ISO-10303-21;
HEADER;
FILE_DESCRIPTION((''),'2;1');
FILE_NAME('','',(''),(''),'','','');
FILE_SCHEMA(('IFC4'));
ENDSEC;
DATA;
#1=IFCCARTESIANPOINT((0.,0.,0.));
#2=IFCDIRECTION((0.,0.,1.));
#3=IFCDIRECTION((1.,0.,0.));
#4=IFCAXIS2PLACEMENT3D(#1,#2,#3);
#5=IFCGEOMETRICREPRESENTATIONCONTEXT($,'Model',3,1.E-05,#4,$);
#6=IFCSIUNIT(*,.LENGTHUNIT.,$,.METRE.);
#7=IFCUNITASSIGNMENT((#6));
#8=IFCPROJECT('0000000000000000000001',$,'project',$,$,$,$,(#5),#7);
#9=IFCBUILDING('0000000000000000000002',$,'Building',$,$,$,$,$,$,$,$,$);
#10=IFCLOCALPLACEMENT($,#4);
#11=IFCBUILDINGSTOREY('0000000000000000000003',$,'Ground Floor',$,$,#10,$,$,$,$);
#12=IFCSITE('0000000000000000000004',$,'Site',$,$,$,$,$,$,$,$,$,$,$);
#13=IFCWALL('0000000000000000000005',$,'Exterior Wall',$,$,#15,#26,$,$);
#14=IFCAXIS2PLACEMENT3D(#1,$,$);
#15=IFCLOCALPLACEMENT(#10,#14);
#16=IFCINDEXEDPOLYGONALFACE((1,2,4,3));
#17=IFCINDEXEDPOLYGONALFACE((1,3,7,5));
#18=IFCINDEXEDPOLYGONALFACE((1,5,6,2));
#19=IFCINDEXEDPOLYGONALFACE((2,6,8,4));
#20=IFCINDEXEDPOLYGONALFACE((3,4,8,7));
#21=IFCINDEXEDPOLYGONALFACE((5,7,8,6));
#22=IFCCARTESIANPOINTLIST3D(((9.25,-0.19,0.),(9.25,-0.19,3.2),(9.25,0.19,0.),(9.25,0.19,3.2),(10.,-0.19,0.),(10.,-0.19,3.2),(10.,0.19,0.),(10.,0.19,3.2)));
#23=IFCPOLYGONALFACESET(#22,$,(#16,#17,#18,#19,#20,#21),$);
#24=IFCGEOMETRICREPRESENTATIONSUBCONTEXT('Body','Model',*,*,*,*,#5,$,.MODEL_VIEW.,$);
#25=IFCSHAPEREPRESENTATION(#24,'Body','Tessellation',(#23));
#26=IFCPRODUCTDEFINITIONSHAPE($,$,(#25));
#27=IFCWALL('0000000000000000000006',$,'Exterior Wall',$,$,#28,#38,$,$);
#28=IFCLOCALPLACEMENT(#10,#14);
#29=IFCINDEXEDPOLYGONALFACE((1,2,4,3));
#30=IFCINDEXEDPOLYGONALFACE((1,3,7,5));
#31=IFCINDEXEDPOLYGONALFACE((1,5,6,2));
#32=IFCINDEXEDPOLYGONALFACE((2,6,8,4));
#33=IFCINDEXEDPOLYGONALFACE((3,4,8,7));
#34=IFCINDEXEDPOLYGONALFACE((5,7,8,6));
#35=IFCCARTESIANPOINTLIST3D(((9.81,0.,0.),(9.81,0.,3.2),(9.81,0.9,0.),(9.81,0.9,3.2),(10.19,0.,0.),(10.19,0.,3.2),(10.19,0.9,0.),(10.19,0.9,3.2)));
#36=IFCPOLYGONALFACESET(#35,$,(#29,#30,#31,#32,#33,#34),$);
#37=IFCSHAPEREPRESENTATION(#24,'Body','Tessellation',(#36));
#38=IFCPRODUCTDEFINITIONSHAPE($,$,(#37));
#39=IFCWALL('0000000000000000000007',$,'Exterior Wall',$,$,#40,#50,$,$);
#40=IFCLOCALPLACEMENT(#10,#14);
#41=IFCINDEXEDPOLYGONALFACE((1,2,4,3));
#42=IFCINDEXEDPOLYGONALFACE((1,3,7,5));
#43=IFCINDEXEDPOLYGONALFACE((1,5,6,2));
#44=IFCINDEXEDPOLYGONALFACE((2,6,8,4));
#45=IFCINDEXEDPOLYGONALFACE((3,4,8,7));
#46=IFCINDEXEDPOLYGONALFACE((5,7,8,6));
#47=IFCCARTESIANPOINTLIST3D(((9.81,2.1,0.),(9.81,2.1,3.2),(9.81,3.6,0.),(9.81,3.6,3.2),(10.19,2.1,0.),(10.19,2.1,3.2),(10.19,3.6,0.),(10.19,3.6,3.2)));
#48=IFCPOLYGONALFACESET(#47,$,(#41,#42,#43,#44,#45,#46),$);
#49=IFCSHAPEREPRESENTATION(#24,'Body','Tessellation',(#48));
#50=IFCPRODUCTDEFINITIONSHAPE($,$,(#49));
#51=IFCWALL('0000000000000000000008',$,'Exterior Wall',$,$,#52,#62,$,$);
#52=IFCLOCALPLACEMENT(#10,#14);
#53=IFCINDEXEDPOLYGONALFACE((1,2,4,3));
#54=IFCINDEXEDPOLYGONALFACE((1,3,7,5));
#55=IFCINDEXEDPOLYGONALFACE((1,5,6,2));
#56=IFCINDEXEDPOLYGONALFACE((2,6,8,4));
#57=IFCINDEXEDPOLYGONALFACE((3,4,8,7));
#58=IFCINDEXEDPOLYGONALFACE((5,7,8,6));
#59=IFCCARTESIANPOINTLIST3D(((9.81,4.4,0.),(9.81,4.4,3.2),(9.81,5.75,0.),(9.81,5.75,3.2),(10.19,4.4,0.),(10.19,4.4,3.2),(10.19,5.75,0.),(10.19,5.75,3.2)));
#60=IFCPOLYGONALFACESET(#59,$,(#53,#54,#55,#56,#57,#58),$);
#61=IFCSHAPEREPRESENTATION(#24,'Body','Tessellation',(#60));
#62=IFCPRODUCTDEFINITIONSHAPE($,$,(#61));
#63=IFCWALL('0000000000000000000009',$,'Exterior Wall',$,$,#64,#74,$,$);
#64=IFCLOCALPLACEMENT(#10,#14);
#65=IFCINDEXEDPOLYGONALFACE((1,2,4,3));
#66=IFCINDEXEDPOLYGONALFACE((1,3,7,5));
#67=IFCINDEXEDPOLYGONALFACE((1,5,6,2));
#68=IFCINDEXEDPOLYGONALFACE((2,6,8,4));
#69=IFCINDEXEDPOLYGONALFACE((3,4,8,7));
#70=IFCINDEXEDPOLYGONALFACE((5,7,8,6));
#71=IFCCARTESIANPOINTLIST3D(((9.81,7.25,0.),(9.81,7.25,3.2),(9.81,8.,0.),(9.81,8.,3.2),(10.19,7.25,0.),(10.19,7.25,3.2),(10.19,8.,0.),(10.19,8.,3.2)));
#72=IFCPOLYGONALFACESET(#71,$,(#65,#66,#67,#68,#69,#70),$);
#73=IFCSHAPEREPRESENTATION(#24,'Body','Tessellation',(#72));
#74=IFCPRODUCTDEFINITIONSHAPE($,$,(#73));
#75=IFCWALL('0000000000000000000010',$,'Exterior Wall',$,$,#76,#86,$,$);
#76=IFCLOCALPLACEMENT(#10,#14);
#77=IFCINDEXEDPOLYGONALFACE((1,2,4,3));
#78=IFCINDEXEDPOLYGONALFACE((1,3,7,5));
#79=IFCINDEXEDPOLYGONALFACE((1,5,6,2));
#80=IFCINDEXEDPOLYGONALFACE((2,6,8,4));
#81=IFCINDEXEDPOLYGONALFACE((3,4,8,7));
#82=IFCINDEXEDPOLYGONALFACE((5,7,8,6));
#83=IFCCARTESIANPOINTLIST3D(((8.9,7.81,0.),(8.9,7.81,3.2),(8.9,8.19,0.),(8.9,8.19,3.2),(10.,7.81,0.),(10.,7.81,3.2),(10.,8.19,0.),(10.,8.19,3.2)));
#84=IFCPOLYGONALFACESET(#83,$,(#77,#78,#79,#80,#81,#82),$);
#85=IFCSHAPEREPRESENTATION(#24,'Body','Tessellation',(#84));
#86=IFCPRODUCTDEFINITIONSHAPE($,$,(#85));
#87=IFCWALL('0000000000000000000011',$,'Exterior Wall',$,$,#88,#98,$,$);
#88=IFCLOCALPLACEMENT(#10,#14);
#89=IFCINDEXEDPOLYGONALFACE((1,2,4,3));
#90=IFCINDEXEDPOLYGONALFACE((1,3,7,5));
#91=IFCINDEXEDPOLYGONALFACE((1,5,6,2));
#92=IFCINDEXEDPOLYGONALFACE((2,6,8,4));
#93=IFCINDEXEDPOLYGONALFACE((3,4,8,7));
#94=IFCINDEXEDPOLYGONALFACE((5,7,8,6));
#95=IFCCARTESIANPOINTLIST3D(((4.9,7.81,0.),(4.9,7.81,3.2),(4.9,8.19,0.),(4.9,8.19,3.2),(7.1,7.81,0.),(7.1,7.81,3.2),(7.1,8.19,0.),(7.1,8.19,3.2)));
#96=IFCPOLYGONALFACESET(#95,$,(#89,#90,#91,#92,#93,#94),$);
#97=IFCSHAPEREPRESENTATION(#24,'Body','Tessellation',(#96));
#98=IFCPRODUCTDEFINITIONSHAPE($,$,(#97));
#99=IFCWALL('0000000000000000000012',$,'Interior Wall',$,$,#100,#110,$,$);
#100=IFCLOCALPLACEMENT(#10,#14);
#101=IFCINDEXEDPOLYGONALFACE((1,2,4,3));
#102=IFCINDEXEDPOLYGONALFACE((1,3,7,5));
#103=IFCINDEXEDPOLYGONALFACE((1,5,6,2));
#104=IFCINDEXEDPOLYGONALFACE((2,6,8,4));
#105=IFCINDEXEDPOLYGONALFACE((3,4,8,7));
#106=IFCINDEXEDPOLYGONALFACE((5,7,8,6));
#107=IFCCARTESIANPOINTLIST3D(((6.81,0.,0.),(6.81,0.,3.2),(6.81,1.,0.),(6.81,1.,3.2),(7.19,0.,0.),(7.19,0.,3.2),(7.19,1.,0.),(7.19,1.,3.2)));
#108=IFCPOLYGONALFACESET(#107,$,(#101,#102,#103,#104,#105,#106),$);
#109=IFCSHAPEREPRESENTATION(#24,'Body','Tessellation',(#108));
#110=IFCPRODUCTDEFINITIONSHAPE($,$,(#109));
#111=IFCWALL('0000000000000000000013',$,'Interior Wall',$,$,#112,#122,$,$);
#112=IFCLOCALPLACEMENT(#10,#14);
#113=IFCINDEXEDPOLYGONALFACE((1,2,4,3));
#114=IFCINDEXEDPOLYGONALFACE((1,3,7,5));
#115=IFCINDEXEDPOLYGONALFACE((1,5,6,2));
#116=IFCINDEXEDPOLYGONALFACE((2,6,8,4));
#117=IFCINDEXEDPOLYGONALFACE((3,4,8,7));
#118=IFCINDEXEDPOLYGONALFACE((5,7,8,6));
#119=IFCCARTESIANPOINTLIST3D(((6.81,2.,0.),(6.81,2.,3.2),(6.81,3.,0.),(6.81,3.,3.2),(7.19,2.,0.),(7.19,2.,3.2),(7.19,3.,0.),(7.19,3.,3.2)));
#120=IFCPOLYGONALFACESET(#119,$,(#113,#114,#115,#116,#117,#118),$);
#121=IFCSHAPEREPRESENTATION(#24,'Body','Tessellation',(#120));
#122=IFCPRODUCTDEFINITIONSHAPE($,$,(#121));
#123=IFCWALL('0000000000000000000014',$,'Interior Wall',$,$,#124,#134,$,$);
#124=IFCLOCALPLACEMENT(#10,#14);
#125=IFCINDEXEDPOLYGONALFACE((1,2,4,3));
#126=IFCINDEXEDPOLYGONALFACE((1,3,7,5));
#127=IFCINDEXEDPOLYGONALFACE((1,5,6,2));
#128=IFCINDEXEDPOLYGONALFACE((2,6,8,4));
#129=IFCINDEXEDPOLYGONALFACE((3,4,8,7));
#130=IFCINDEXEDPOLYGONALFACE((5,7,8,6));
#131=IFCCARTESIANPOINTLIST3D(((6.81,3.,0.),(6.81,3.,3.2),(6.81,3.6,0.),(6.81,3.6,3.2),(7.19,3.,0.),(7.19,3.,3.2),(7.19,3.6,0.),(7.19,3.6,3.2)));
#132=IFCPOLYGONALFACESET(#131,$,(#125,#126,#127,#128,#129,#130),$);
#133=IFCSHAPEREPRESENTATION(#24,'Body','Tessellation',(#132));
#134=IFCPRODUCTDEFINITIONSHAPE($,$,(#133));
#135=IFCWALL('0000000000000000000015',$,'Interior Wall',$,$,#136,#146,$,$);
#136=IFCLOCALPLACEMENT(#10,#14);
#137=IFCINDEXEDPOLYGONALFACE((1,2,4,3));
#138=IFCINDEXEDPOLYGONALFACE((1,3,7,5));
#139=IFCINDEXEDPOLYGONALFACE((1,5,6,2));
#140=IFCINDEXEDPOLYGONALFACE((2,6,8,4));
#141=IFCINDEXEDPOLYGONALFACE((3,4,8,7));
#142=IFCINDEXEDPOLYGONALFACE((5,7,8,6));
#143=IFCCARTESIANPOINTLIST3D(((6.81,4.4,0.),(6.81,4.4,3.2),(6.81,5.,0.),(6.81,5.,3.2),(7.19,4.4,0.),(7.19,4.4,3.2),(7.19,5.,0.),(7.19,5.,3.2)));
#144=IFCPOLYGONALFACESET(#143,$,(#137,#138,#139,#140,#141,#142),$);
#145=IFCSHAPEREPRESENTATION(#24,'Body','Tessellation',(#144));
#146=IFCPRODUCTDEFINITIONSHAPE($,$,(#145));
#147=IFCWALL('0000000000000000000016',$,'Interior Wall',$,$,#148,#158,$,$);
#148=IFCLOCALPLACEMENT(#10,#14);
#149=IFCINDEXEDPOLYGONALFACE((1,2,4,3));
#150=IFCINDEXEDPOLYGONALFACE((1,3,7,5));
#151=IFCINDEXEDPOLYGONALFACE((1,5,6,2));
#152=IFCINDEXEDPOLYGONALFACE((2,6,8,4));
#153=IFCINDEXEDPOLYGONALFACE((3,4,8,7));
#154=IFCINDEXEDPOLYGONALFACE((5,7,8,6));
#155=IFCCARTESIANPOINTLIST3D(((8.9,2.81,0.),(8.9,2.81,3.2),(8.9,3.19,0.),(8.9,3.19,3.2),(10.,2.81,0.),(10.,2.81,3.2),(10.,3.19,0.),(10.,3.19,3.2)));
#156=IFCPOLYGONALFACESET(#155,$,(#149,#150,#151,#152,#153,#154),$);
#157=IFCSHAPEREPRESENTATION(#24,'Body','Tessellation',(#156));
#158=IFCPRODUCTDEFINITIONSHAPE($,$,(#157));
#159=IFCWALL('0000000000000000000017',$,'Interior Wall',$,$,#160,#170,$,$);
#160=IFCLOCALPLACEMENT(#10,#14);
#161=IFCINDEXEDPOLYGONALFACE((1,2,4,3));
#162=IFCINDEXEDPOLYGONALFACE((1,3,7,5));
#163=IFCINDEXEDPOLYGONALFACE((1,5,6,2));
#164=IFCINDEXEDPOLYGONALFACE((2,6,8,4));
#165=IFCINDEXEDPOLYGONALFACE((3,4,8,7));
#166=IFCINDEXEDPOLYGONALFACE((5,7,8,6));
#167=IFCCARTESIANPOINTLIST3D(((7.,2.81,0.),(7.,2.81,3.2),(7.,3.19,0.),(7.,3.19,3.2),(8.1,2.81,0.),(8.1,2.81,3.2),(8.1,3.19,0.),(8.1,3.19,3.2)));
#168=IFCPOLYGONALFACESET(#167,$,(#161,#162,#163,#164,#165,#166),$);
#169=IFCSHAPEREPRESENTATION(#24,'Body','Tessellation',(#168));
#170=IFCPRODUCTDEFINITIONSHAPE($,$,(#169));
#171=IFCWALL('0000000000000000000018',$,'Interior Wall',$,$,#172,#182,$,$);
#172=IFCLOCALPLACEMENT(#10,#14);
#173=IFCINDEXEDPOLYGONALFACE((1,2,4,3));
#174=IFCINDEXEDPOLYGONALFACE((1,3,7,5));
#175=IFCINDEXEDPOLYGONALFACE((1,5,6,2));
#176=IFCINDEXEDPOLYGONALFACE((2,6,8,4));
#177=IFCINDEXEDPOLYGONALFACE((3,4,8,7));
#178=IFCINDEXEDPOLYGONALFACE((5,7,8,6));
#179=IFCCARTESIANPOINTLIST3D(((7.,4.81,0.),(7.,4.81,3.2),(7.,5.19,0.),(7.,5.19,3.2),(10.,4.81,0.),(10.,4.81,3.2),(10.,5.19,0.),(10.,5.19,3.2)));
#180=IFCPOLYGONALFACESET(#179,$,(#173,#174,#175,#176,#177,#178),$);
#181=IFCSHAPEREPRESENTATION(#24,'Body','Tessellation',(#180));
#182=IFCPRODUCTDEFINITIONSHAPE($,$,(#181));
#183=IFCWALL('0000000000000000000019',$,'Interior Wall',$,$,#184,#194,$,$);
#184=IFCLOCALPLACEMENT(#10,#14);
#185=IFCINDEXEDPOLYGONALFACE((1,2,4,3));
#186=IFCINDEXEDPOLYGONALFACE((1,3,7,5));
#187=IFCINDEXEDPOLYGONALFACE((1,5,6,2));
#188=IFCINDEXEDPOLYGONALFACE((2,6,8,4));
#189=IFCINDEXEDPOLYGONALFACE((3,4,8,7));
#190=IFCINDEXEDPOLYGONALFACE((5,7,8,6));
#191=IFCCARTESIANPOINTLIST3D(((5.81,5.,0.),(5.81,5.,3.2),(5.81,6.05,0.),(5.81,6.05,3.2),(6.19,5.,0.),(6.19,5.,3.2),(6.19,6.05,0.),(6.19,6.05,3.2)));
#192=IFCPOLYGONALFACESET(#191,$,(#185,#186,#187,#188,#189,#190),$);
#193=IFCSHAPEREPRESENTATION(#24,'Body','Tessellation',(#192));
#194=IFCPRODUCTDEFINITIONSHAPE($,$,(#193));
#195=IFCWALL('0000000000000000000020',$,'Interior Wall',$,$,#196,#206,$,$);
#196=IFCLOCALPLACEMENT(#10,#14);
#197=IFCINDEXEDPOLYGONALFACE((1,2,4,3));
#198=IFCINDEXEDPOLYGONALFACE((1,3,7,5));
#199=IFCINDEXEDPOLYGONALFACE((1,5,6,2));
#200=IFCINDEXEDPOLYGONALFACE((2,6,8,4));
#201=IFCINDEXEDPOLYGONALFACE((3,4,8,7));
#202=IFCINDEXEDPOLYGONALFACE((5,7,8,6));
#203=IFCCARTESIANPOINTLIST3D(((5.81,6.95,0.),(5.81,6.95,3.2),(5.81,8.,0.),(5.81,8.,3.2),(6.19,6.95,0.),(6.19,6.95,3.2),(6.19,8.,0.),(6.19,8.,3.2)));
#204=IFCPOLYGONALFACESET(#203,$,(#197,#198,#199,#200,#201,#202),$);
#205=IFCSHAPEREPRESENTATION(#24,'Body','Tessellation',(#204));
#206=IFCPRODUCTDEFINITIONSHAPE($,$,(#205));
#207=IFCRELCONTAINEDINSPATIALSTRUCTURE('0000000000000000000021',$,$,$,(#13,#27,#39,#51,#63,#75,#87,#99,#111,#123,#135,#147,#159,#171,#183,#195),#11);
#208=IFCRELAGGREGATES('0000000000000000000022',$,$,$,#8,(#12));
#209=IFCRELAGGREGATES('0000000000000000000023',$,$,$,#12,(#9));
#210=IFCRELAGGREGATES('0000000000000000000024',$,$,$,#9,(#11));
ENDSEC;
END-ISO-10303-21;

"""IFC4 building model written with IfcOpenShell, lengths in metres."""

from ifc_helpers import new_model, si_unit, frame, origin_with_axes, place, context, subcontext, project, spatial, indexed_curve, outline, extrude, element, save


model = new_model("IFC4")

# Units and contexts
model_context = context("Model", 3, precision=1e-05, world=origin_with_axes())
body_context = subcontext(model_context, "Body", "Model", "MODEL_VIEW")
ifc_project = project(units=[si_unit("LENGTHUNIT", "METRE")], contexts=[model_context])

# Site, building, storey
site = spatial("IfcSite", under=ifc_project, Name="Site")
building = spatial("IfcBuilding", under=site, Name="Building")
storey_placement = place(None, origin_with_axes())
storey = spatial("IfcBuildingStorey", under=building, at=storey_placement, Name="Ground Floor")

# Walls
wall_1_placement = place(storey_placement, frame((9.25, 0.0, 0.0), z_axis=(0.0, 0.0, 1.0), x_axis=(1.0, 0.0, 0.0)))
element("IfcWall", 1, at=wall_1_placement, inside=storey, Name="Exterior Wall", context=body_context, shape_type="SweptSolid", body=[
    extrude(outline(indexed_curve([(0.0, 0.0), (0.0, 0.38), (0.75, 0.38), (0.75, 0.0), (0.0, 0.0)], self_intersect=False)), frame((0.0, -0.19, 0.0), z_axis=(0.0, 0.0, 1.0), x_axis=(1.0, 0.0, 0.0)), (0.0, 0.0, 1.0), 3.2),
])
wall_2_placement = place(storey_placement, frame((10.0, 0.0, 0.0), z_axis=(0.0, 0.0, 1.0), x_axis=(0.0, 1.0, 0.0)))
element("IfcWall", 2, at=wall_2_placement, inside=storey, Name="Exterior Wall", context=body_context, shape_type="SweptSolid", body=[
    extrude(outline(indexed_curve([(0.0, 0.0), (0.0, 0.38), (0.9, 0.38), (0.9, 0.0), (0.0, 0.0)], self_intersect=False)), frame((0.0, -0.19, 0.0), z_axis=(0.0, 0.0, 1.0), x_axis=(1.0, 0.0, 0.0)), (0.0, 0.0, 1.0), 3.2),
])
wall_3_placement = place(storey_placement, frame((10.0, 2.1, 0.0), z_axis=(0.0, 0.0, 1.0), x_axis=(0.0, 1.0, 0.0)))
element("IfcWall", 3, at=wall_3_placement, inside=storey, Name="Exterior Wall", context=body_context, shape_type="SweptSolid", body=[
    extrude(outline(indexed_curve([(0.0, 0.0), (0.0, 0.38), (1.5, 0.38), (1.5, 0.0), (0.0, 0.0)], self_intersect=False)), frame((0.0, -0.19, 0.0), z_axis=(0.0, 0.0, 1.0), x_axis=(1.0, 0.0, 0.0)), (0.0, 0.0, 1.0), 3.2),
])
wall_4_placement = place(storey_placement, frame((10.0, 4.4, 0.0), z_axis=(0.0, 0.0, 1.0), x_axis=(0.0, 1.0, 0.0)))
element("IfcWall", 4, at=wall_4_placement, inside=storey, Name="Exterior Wall", context=body_context, shape_type="SweptSolid", body=[
    extrude(outline(indexed_curve([(0.0, 0.0), (0.0, 0.38), (1.35, 0.38), (1.35, 0.0), (0.0, 0.0)], self_intersect=False)), frame((0.0, -0.19, 0.0), z_axis=(0.0, 0.0, 1.0), x_axis=(1.0, 0.0, 0.0)), (0.0, 0.0, 1.0), 3.2),
])
wall_5_placement = place(storey_placement, frame((10.0, 7.25, 0.0), z_axis=(0.0, 0.0, 1.0), x_axis=(0.0, 1.0, 0.0)))
element("IfcWall", 5, at=wall_5_placement, inside=storey, Name="Exterior Wall", context=body_context, shape_type="SweptSolid", body=[
    extrude(outline(indexed_curve([(0.0, 0.0), (0.0, 0.38), (0.75, 0.38), (0.75, 0.0), (0.0, 0.0)], self_intersect=False)), frame((0.0, -0.19, 0.0), z_axis=(0.0, 0.0, 1.0), x_axis=(1.0, 0.0, 0.0)), (0.0, 0.0, 1.0), 3.2),
])
wall_6_placement = place(storey_placement, frame((10.0, 8.0, 0.0), z_axis=(0.0, 0.0, 1.0), x_axis=(-1.0, 0.0, 0.0)))
element("IfcWall", 6, at=wall_6_placement, inside=storey, Name="Exterior Wall", context=body_context, shape_type="SweptSolid", body=[
    extrude(outline(indexed_curve([(0.0, 0.0), (0.0, 0.38), (1.1, 0.38), (1.1, 0.0), (0.0, 0.0)], self_intersect=False)), frame((0.0, -0.19, 0.0), z_axis=(0.0, 0.0, 1.0), x_axis=(1.0, 0.0, 0.0)), (0.0, 0.0, 1.0), 3.2),
])
wall_7_placement = place(storey_placement, frame((7.1, 8.0, 0.0), z_axis=(0.0, 0.0, 1.0), x_axis=(-1.0, 0.0, 0.0)))
element("IfcWall", 7, at=wall_7_placement, inside=storey, Name="Exterior Wall", context=body_context, shape_type="SweptSolid", body=[
    extrude(outline(indexed_curve([(0.0, 0.0), (0.0, 0.38), (2.2, 0.38), (2.2, 0.0), (0.0, 0.0)], self_intersect=False)), frame((0.0, -0.19, 0.0), z_axis=(0.0, 0.0, 1.0), x_axis=(1.0, 0.0, 0.0)), (0.0, 0.0, 1.0), 3.2),
])
for number, where, z_axis, x_axis, name in (
    (8, (7.0, 0.0, 0.0), (0.0, 0.0, 1.0), (0.0, 1.0, 0.0), "Interior Wall"),
    (9, (7.0, 2.0, 0.0), (0.0, 0.0, 1.0), (0.0, 1.0, 0.0), "Interior Wall"),
):
    element("IfcWall", number, at=place(storey_placement, frame(where, z_axis=z_axis, x_axis=x_axis)), inside=storey, Name=name, context=body_context, shape_type="SweptSolid", body=[
        extrude(outline(indexed_curve([(0.0, 0.0), (0.0, 0.38), (1.0, 0.38), (1.0, 0.0), (0.0, 0.0)], self_intersect=False)), frame((0.0, -0.19, 0.0), z_axis=(0.0, 0.0, 1.0), x_axis=(1.0, 0.0, 0.0)), (0.0, 0.0, 1.0), 3.2),
    ])
wall_8_placement = place(storey_placement, frame((7.0, 3.0, 0.0), z_axis=(0.0, 0.0, 1.0), x_axis=(0.0, 1.0, 0.0)))
element("IfcWall", 10, at=wall_8_placement, inside=storey, Name="Interior Wall", context=body_context, shape_type="SweptSolid", body=[
    extrude(outline(indexed_curve([(0.0, 0.0), (0.0, 0.38), (0.6, 0.38), (0.6, 0.0), (0.0, 0.0)], self_intersect=False)), frame((0.0, -0.19, 0.0), z_axis=(0.0, 0.0, 1.0), x_axis=(1.0, 0.0, 0.0)), (0.0, 0.0, 1.0), 3.2),
])
wall_9_placement = place(storey_placement, frame((7.0, 4.4, 0.0), z_axis=(0.0, 0.0, 1.0), x_axis=(0.0, 1.0, 0.0)))
element("IfcWall", 11, at=wall_9_placement, inside=storey, Name="Interior Wall", context=body_context, shape_type="SweptSolid", body=[
    extrude(outline(indexed_curve([(0.0, 0.0), (0.0, 0.38), (0.6, 0.38), (0.6, 0.0), (0.0, 0.0)], self_intersect=False)), frame((0.0, -0.19, 0.0), z_axis=(0.0, 0.0, 1.0), x_axis=(1.0, 0.0, 0.0)), (0.0, 0.0, 1.0), 3.2),
])
for number, where, z_axis, x_axis, name in (
    (12, (10.0, 3.0, 0.0), (0.0, 0.0, 1.0), (-1.0, 0.0, 0.0), "Interior Wall"),
    (13, (8.1, 3.0, 0.0), (0.0, 0.0, 1.0), (-1.0, 0.0, 0.0), "Interior Wall"),
):
    element("IfcWall", number, at=place(storey_placement, frame(where, z_axis=z_axis, x_axis=x_axis)), inside=storey, Name=name, context=body_context, shape_type="SweptSolid", body=[
        extrude(outline(indexed_curve([(0.0, 0.0), (0.0, 0.38), (1.1, 0.38), (1.1, 0.0), (0.0, 0.0)], self_intersect=False)), frame((0.0, -0.19, 0.0), z_axis=(0.0, 0.0, 1.0), x_axis=(1.0, 0.0, 0.0)), (0.0, 0.0, 1.0), 3.2),
    ])
wall_10_placement = place(storey_placement, frame((10.0, 5.0, 0.0), z_axis=(0.0, 0.0, 1.0), x_axis=(-1.0, 0.0, 0.0)))
element("IfcWall", 14, at=wall_10_placement, inside=storey, Name="Interior Wall", context=body_context, shape_type="SweptSolid", body=[
    extrude(outline(indexed_curve([(0.0, 0.0), (0.0, 0.38), (3.0, 0.38), (3.0, 0.0), (0.0, 0.0)], self_intersect=False)), frame((0.0, -0.19, 0.0), z_axis=(0.0, 0.0, 1.0), x_axis=(1.0, 0.0, 0.0)), (0.0, 0.0, 1.0), 3.2),
])
for number, where, z_axis, x_axis, name in (
    (15, (6.0, 5.0, 0.0), (0.0, 0.0, 1.0), (0.0, 1.0, 0.0), "Interior Wall"),
    (16, (6.0, 6.95, 0.0), (0.0, 0.0, 1.0), (0.0, 1.0, 0.0), "Interior Wall"),
):
    element("IfcWall", number, at=place(storey_placement, frame(where, z_axis=z_axis, x_axis=x_axis)), inside=storey, Name=name, context=body_context, shape_type="SweptSolid", body=[
        extrude(outline(indexed_curve([(0.0, 0.0), (0.0, 0.38), (1.05, 0.38), (1.05, 0.0), (0.0, 0.0)], self_intersect=False)), frame((0.0, -0.19, 0.0), z_axis=(0.0, 0.0, 1.0), x_axis=(1.0, 0.0, 0.0)), (0.0, 0.0, 1.0), 3.2),
    ])

save(model, "model.ifc")
